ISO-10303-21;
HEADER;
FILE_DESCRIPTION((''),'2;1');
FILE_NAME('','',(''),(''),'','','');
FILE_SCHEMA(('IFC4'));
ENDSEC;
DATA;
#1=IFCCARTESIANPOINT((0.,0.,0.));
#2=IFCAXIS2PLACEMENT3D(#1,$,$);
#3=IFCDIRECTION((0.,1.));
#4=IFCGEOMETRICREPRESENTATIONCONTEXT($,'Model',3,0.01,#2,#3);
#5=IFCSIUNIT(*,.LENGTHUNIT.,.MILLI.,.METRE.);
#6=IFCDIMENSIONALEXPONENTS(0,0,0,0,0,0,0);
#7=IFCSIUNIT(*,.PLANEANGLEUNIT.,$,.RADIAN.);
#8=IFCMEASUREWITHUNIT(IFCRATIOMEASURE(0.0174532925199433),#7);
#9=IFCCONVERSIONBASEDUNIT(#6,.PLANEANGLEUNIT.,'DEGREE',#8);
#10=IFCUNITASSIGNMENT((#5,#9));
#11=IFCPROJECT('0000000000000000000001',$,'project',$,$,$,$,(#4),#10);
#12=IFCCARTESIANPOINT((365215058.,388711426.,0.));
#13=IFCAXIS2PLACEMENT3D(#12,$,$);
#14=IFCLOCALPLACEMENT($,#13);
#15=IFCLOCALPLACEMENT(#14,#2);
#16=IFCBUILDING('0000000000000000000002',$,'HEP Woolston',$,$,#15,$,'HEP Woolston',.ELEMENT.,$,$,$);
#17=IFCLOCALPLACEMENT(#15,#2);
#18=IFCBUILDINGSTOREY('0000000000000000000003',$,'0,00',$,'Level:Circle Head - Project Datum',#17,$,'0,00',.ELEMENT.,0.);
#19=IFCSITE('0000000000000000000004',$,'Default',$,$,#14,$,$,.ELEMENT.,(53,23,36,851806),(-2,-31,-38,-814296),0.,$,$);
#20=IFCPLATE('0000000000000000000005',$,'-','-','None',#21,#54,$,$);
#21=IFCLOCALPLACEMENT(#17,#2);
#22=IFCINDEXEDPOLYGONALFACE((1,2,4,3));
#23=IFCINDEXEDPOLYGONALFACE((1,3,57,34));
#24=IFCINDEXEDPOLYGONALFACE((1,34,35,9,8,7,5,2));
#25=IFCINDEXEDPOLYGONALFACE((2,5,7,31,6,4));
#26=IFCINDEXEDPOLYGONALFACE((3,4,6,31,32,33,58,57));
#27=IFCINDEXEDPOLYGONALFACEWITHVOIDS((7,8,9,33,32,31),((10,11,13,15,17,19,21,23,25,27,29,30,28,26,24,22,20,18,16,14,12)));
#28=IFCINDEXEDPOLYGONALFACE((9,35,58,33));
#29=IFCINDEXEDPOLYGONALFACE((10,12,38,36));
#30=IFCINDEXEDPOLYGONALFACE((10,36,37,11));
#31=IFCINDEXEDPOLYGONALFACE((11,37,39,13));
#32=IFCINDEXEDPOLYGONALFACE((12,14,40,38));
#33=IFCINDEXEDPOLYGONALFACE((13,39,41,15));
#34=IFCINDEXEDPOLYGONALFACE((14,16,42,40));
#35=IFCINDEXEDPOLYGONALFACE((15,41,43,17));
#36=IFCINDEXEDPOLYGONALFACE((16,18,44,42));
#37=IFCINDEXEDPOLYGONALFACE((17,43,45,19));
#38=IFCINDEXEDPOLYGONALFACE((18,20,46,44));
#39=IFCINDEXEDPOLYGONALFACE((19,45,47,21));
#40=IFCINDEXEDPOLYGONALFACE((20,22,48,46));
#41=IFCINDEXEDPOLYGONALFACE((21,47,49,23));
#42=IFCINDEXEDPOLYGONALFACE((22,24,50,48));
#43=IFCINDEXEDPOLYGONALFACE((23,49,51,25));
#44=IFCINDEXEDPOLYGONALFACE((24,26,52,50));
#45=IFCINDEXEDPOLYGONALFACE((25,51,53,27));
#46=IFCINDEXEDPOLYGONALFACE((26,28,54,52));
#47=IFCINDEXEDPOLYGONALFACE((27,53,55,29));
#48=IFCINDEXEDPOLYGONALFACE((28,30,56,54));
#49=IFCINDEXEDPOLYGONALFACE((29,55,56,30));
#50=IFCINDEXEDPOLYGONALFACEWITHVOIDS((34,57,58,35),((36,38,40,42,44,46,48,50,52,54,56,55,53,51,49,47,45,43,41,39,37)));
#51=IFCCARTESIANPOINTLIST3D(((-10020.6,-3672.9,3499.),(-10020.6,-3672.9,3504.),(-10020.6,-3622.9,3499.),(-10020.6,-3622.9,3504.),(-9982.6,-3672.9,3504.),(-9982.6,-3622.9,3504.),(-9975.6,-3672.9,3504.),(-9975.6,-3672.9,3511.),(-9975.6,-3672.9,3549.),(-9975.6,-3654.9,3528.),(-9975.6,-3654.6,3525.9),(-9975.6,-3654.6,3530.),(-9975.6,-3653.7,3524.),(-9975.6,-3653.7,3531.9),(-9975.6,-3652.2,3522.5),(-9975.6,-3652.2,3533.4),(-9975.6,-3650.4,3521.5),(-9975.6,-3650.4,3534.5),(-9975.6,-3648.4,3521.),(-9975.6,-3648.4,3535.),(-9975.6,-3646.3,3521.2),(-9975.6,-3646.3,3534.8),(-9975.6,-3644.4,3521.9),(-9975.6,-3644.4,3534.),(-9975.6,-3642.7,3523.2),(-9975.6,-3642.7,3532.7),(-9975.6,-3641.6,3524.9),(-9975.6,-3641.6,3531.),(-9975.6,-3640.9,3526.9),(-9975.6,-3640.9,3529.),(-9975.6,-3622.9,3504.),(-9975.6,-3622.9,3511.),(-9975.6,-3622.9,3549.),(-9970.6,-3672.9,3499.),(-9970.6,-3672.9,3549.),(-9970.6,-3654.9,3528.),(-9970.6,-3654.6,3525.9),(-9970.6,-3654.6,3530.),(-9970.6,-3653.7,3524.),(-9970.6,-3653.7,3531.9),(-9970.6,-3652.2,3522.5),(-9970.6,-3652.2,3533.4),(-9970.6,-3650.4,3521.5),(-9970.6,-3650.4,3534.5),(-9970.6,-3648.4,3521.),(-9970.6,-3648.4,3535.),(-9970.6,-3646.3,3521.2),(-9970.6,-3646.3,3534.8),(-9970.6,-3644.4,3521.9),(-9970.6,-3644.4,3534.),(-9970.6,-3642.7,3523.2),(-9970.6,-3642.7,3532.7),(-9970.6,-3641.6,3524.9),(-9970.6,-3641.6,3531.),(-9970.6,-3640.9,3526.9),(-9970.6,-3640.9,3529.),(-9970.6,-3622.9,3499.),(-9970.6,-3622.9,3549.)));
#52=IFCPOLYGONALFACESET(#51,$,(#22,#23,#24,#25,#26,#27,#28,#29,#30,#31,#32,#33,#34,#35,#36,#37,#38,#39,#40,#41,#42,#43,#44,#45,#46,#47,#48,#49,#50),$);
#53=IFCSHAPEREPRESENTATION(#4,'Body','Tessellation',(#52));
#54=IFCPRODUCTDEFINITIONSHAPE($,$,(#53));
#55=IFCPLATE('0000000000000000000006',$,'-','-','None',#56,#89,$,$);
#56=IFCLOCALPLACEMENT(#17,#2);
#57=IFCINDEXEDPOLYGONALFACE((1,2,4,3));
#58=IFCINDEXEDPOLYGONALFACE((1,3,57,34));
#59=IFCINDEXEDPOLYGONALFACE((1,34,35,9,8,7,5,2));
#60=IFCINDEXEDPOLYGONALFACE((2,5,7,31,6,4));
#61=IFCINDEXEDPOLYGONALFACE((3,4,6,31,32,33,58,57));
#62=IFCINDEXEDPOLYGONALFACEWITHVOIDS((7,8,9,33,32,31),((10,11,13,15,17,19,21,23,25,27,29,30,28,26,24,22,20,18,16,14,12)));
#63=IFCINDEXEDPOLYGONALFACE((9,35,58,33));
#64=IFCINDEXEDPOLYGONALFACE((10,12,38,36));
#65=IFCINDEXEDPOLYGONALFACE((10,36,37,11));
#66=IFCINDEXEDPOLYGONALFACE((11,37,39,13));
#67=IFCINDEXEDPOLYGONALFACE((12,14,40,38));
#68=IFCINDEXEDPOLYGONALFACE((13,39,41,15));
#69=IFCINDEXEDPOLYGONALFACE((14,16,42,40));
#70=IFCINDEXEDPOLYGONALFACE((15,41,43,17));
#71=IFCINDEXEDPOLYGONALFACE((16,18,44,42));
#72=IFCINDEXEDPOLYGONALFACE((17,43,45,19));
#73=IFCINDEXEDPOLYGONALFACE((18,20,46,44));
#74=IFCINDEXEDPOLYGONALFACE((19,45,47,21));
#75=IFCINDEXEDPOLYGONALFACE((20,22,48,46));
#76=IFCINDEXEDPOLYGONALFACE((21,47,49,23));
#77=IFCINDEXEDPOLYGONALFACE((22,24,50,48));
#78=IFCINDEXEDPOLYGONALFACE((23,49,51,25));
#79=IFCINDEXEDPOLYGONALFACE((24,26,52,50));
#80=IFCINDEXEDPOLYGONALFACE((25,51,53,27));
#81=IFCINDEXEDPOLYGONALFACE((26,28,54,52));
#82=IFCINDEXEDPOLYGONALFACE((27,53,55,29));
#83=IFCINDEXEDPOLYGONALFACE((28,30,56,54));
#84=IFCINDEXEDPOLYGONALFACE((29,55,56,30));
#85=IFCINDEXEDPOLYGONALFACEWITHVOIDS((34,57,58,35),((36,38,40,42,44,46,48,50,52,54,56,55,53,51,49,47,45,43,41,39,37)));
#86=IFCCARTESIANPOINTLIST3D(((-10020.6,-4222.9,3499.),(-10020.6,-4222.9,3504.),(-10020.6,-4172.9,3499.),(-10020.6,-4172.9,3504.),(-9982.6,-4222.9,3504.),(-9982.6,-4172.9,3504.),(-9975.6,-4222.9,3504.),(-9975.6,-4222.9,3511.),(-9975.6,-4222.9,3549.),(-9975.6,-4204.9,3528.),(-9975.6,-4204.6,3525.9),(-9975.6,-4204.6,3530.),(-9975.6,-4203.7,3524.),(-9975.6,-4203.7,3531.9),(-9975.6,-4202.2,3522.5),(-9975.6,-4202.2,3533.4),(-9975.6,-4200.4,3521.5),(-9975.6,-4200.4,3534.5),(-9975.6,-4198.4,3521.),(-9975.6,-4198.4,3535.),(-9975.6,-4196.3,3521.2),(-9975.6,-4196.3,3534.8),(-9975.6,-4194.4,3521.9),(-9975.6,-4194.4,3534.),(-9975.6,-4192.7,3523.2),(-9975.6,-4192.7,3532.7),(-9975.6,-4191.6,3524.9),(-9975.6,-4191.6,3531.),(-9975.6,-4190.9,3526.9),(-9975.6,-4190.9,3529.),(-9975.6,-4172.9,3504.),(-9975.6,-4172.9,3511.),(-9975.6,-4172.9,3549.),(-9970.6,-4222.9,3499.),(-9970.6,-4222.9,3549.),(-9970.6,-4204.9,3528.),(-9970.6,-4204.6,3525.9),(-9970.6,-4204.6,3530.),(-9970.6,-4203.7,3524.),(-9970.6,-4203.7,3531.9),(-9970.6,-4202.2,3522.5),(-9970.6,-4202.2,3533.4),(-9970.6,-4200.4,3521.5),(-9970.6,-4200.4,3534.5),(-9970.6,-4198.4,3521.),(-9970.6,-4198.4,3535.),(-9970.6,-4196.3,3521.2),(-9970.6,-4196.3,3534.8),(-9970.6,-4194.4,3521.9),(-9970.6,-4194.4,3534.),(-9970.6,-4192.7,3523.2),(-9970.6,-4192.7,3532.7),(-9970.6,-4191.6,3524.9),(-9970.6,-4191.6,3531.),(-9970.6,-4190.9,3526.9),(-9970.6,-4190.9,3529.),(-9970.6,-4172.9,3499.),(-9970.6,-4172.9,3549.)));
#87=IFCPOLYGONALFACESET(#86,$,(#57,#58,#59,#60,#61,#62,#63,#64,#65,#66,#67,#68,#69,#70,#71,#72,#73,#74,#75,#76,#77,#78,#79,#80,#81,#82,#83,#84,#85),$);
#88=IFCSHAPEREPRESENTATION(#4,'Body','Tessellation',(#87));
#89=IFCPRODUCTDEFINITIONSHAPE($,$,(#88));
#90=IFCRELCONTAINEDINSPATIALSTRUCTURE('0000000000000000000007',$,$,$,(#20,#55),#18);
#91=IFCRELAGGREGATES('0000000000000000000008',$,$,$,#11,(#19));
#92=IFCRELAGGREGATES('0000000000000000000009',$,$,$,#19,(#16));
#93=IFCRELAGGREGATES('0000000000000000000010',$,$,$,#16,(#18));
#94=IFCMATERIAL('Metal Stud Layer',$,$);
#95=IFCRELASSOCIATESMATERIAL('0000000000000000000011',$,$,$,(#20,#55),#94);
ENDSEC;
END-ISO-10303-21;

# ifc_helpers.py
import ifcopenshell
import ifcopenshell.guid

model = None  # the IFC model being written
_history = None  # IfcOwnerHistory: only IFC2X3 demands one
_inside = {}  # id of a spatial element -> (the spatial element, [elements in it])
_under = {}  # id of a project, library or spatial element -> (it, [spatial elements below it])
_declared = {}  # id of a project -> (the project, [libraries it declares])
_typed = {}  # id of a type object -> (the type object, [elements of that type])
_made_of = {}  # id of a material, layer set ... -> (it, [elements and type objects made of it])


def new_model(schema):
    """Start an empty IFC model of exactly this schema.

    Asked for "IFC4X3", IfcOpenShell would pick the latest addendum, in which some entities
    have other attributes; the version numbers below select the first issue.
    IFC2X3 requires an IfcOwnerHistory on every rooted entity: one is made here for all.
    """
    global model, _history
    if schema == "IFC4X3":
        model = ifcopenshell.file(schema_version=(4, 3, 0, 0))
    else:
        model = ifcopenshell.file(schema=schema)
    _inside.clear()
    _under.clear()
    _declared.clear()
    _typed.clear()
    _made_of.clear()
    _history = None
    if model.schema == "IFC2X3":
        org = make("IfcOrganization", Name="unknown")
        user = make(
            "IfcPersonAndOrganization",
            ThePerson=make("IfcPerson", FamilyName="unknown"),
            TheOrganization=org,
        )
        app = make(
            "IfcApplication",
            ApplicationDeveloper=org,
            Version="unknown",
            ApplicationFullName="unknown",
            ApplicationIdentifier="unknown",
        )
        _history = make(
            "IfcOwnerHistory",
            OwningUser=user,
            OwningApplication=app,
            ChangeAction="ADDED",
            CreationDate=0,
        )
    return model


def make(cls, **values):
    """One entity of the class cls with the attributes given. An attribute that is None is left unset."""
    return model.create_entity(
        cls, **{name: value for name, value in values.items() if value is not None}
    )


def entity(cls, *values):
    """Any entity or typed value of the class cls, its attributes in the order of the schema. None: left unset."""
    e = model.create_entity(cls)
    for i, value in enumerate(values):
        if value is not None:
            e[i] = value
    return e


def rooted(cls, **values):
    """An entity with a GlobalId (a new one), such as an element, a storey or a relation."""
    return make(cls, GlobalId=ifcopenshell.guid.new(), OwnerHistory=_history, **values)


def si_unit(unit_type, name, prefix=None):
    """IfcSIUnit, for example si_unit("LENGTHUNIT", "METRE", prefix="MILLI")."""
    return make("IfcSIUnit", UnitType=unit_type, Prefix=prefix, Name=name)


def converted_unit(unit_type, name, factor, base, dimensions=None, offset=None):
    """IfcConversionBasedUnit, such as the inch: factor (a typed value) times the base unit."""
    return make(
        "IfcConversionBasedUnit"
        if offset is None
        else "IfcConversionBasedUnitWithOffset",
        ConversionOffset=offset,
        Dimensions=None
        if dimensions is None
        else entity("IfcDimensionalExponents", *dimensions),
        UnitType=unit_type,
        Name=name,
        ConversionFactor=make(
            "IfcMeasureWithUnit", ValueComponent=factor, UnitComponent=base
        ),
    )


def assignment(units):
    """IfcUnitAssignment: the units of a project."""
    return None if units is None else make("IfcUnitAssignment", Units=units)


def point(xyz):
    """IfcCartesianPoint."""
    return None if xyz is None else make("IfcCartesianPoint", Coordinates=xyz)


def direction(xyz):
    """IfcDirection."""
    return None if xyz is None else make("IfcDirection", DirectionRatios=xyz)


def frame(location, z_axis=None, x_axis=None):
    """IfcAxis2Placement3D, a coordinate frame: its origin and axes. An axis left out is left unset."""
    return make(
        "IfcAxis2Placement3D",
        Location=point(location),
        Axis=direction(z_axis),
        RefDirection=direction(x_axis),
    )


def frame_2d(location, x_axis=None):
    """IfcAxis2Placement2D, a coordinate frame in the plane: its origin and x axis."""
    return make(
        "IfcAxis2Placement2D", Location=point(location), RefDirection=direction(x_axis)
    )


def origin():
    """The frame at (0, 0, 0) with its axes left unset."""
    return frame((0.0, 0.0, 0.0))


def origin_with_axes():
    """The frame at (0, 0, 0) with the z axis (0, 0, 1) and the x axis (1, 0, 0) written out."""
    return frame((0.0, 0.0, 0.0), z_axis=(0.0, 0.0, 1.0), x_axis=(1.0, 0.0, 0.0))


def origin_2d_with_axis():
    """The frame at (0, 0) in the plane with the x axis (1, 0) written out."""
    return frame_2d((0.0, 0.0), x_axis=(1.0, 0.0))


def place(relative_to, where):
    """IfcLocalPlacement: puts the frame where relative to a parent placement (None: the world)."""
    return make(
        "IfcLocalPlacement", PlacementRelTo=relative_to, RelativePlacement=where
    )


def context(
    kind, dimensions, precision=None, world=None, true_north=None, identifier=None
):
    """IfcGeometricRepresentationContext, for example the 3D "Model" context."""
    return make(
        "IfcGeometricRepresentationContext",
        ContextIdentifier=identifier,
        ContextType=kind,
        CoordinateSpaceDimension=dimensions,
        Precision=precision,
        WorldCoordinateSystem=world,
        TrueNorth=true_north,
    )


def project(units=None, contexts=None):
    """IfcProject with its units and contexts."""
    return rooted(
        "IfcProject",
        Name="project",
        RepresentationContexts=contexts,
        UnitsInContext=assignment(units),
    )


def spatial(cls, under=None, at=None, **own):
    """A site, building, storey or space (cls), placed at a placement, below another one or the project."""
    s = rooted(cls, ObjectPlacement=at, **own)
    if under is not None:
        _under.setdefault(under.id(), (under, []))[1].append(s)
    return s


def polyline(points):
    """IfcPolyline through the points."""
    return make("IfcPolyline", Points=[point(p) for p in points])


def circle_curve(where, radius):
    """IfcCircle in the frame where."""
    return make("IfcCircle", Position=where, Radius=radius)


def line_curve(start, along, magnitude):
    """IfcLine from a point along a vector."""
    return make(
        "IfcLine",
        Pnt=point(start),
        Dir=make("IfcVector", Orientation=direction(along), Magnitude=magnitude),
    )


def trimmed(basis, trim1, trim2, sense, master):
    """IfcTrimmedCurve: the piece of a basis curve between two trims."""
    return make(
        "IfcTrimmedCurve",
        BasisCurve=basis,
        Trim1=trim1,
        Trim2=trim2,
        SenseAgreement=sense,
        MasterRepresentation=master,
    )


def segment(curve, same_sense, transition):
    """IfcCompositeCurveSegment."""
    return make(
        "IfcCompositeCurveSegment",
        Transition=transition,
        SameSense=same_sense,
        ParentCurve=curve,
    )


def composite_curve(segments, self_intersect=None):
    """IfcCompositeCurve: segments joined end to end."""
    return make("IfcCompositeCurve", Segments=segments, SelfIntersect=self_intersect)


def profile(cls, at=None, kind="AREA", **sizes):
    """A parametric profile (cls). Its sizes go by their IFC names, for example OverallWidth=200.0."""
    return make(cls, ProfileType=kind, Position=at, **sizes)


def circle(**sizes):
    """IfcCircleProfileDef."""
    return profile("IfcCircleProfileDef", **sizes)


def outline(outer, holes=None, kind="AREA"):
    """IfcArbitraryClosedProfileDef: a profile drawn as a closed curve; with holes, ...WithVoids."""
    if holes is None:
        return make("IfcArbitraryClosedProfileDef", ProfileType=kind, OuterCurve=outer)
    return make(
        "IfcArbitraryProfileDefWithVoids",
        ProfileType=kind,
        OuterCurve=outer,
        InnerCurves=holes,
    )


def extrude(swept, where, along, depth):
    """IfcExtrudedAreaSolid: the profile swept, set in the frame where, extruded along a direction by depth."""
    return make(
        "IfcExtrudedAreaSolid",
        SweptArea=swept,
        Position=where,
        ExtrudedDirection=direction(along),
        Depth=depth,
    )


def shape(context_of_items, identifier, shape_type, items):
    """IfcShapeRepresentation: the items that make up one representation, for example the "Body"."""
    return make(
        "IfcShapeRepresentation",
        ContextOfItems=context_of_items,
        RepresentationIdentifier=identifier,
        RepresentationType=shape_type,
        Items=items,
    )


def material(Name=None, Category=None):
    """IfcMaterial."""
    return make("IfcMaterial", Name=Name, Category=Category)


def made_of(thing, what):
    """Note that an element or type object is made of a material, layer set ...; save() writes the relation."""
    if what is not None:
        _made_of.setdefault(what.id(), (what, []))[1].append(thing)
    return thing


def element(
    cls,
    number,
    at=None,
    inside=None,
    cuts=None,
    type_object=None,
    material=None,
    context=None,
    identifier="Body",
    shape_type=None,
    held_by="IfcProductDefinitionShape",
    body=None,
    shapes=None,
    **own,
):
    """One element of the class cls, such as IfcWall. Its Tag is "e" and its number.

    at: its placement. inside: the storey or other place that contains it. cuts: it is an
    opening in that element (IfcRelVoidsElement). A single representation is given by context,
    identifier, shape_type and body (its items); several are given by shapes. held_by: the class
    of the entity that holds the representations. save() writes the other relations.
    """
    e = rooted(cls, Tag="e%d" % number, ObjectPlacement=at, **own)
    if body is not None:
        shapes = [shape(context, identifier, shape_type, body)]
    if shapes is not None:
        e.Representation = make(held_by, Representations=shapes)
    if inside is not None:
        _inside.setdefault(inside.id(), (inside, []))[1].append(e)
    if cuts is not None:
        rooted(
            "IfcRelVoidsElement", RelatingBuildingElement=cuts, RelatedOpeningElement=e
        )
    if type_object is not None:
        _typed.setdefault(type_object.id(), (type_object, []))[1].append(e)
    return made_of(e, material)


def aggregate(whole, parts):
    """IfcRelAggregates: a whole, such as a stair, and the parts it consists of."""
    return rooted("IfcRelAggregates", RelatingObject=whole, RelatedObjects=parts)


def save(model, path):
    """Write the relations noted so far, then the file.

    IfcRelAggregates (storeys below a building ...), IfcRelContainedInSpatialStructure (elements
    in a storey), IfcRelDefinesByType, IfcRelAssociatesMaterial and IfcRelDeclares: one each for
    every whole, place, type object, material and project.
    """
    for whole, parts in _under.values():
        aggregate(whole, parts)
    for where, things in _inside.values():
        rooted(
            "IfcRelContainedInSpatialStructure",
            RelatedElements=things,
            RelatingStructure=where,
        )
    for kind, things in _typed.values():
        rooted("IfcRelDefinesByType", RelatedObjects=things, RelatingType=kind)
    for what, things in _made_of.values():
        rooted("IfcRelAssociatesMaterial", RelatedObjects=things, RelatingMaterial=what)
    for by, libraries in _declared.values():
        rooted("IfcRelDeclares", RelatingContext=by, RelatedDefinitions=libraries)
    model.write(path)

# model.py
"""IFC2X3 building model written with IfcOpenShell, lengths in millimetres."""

from ifc_helpers import new_model, entity, si_unit, converted_unit, point, direction, frame, frame_2d, origin, origin_with_axes, origin_2d_with_axis, place, context, project, spatial, polyline, circle_curve, line_curve, trimmed, segment, composite_curve, circle, outline, extrude, material, element, save


model = new_model("IFC2X3")

# Units and contexts
model_context = context("Model", 3, precision=0.01, world=origin(), true_north=direction((0.0, 1.0)))
ifc_project = project(units=[si_unit("LENGTHUNIT", "METRE", prefix="MILLI"), converted_unit("PLANEANGLEUNIT", "DEGREE", entity("IfcRatioMeasure", 0.0174532925199433), si_unit("PLANEANGLEUNIT", "RADIAN"), dimensions=[0, 0, 0, 0, 0, 0, 0])], contexts=[model_context])

# Site, building, storey
site_placement = place(None, frame((365215058.0, 388711426.0, 0.0)))
site = spatial("IfcSite", under=ifc_project, at=site_placement, Name="Default", CompositionType="ELEMENT", RefLatitude=(53, 23, 36, 851806), RefLongitude=(-2, -31, -38, -814296), RefElevation=0.0)
building_placement = place(site_placement, origin())
building = spatial("IfcBuilding", under=site, at=building_placement, Name="HEP Woolston", LongName="HEP Woolston", CompositionType="ELEMENT")
storey_placement = place(building_placement, origin())
storey = spatial("IfcBuildingStorey", under=building, at=storey_placement, Name="0,00", ObjectType="Level:Circle Head - Project Datum", LongName="0,00", CompositionType="ELEMENT", Elevation=0.0)

# Plates, openings
ifc_material = material(Name="Metal Stud Layer")
plate_1_placement = place(storey_placement, frame((-9970.6, -3672.9, 3499.0), z_axis=(0.0, 1.0, 0.0), x_axis=(-1.0, 0.0, 0.0)))
plate_1 = element("IfcPlate", 1, at=plate_1_placement, inside=storey, material=ifc_material, Name="-", Description="-", ObjectType="None", context=model_context, shape_type="SweptSolid", body=[
    extrude(outline(polyline([(0.0, 0.0), (50.0, 0.0), (50.0, 5.0), (5.0, 5.0), (5.0, 50.0), (0.0, 50.0), (0.0, 0.0)])), origin_with_axes(), (0.0, 0.0, 1.0), 50.0),
])
opening_1_placement = place(plate_1_placement, frame((0.0, 0.0, 0.0), z_axis=(0.0, 0.0, 1.0), x_axis=(1.0, 0.0, 0.0)))
element("IfcOpeningElement", 2, at=opening_1_placement, cuts=plate_1, ObjectType="Opening", context=model_context, shape_type="SweptSolid", body=[
    extrude(outline(composite_curve([segment(trimmed(line_curve((50.0, 5.0), (1.0, 0.0), 3.532613), [point((50.0, 5.0))], [point((46.5, 5.0))], True, "CARTESIAN"), True, "CONTINUOUS"), segment(trimmed(circle_curve(frame_2d((46.5, 1.5), x_axis=(-1.0, 0.0)), 3.5), [point((46.5, 5.0))], [point((50.0, 1.5))], False, "CARTESIAN"), True, "CONTINUOUS"), segment(trimmed(line_curve((50.0, 1.5), (0.0, -1.0), 3.532613), [point((50.0, 1.5))], [point((50.0, 5.0))], True, "CARTESIAN"), True, "CONTINUOUS")], self_intersect="UNKNOWN")), origin(), (0.0, 0.0, 1.0), 50.0),
])
opening_2_placement = place(plate_1_placement, origin_with_axes())
element("IfcOpeningElement", 3, at=opening_2_placement, cuts=plate_1, ObjectType="Opening", context=model_context, shape_type="SweptSolid", body=[
    extrude(outline(composite_curve([segment(trimmed(line_curve((5.0, 5.0), (0.0, -1.0), 7.046301), [point((5.0, 5.0))], [point((5.0, 12.0))], False, "CARTESIAN"), True, "CONTINUOUS"), segment(trimmed(circle_curve(frame_2d((12.0, 12.0), x_axis=(1.0, 0.0)), 7.0), [point((5.0, 12.0))], [point((12.0, 5.0))], True, "CARTESIAN"), True, "CONTINUOUS"), segment(trimmed(line_curve((12.0, 5.0), (1.0, 0.0), 7.046301), [point((12.0, 5.0))], [point((5.0, 5.0))], False, "CARTESIAN"), True, "CONTINUOUS")], self_intersect="UNKNOWN")), origin(), (0.0, 0.0, 1.0), 50.0),
])
opening_3_placement = place(plate_1_placement, frame((0.0, 0.0, 0.0), z_axis=(0.0, 0.0, 1.0), x_axis=(1.0, 0.0, 0.0)))
element("IfcOpeningElement", 4, at=opening_3_placement, cuts=plate_1, ObjectType="Opening", context=model_context, shape_type="SweptSolid", body=[
    extrude(outline(composite_curve([segment(trimmed(line_curve((5.0, 50.0), (1.0, 0.0), 3.4874), [point((5.0, 50.0))], [point((1.5, 50.0))], True, "CARTESIAN"), True, "CONTINUOUS"), segment(trimmed(circle_curve(frame_2d((1.5, 46.5), x_axis=(-1.0, 0.0)), 3.5), [point((1.5, 50.0))], [point((5.0, 46.5))], False, "CARTESIAN"), True, "CONTINUOUS"), segment(trimmed(line_curve((5.0, 46.5), (0.0, -1.0), 3.4874), [point((5.0, 46.5))], [point((5.0, 50.0))], True, "CARTESIAN"), True, "CONTINUOUS")], self_intersect="UNKNOWN")), origin(), (0.0, 0.0, 1.0), 50.0),
])
opening_4_placement = place(plate_1_placement, frame((-0.5, 29.0, 25.0), z_axis=(1.0, 0.0, 0.0), x_axis=(0.0, 0.0, -1.0)))
element("IfcOpeningElement", 5, at=opening_4_placement, cuts=plate_1, ObjectType="Opening", context=model_context, shape_type="SweptSolid", body=[
    extrude(circle(Radius=7.0, at=origin_2d_with_axis()), origin(), (0.0, 0.0, 1.0), 6.0),
])
plate_2_placement = place(storey_placement, frame((-9970.6, -4222.9, 3499.0), z_axis=(0.0, 1.0, 0.0), x_axis=(-1.0, 0.0, 0.0)))
plate_2 = element("IfcPlate", 6, at=plate_2_placement, inside=storey, material=ifc_material, Name="-", Description="-", ObjectType="None", context=model_context, shape_type="SweptSolid", body=[
    extrude(outline(polyline([(0.0, 0.0), (50.0, 0.0), (50.0, 5.0), (5.0, 5.0), (5.0, 50.0), (0.0, 50.0), (0.0, 0.0)])), origin_with_axes(), (0.0, 0.0, 1.0), 50.0),
])
opening_5_placement = place(plate_2_placement, frame((0.0, 0.0, 0.0), z_axis=(0.0, 0.0, 1.0), x_axis=(1.0, 0.0, 0.0)))
element("IfcOpeningElement", 7, at=opening_5_placement, cuts=plate_2, ObjectType="Opening", context=model_context, shape_type="SweptSolid", body=[
    extrude(outline(composite_curve([segment(trimmed(line_curve((50.0, 5.0), (1.0, 0.0), 3.532613), [point((50.0, 5.0))], [point((46.5, 5.0))], True, "CARTESIAN"), True, "CONTINUOUS"), segment(trimmed(circle_curve(frame_2d((46.5, 1.5), x_axis=(-1.0, 0.0)), 3.5), [point((46.5, 5.0))], [point((50.0, 1.5))], False, "CARTESIAN"), True, "CONTINUOUS"), segment(trimmed(line_curve((50.0, 1.5), (0.0, -1.0), 3.532613), [point((50.0, 1.5))], [point((50.0, 5.0))], True, "CARTESIAN"), True, "CONTINUOUS")], self_intersect="UNKNOWN")), origin(), (0.0, 0.0, 1.0), 50.0),
])
opening_6_placement = place(plate_2_placement, origin_with_axes())
element("IfcOpeningElement", 8, at=opening_6_placement, cuts=plate_2, ObjectType="Opening", context=model_context, shape_type="SweptSolid", body=[
    extrude(outline(composite_curve([segment(trimmed(line_curve((5.0, 5.0), (0.0, -1.0), 7.046301), [point((5.0, 5.0))], [point((5.0, 12.0))], False, "CARTESIAN"), True, "CONTINUOUS"), segment(trimmed(circle_curve(frame_2d((12.0, 12.0), x_axis=(1.0, 0.0)), 7.0), [point((5.0, 12.0))], [point((12.0, 5.0))], True, "CARTESIAN"), True, "CONTINUOUS"), segment(trimmed(line_curve((12.0, 5.0), (1.0, 0.0), 7.046301), [point((12.0, 5.0))], [point((5.0, 5.0))], False, "CARTESIAN"), True, "CONTINUOUS")], self_intersect="UNKNOWN")), origin(), (0.0, 0.0, 1.0), 50.0),
])
opening_7_placement = place(plate_2_placement, frame((0.0, 0.0, 0.0), z_axis=(0.0, 0.0, 1.0), x_axis=(1.0, 0.0, 0.0)))
element("IfcOpeningElement", 9, at=opening_7_placement, cuts=plate_2, ObjectType="Opening", context=model_context, shape_type="SweptSolid", body=[
    extrude(outline(composite_curve([segment(trimmed(line_curve((5.0, 50.0), (1.0, 0.0), 3.4874), [point((5.0, 50.0))], [point((1.5, 50.0))], True, "CARTESIAN"), True, "CONTINUOUS"), segment(trimmed(circle_curve(frame_2d((1.5, 46.5), x_axis=(-1.0, 0.0)), 3.5), [point((1.5, 50.0))], [point((5.0, 46.5))], False, "CARTESIAN"), True, "CONTINUOUS"), segment(trimmed(line_curve((5.0, 46.5), (0.0, -1.0), 3.4874), [point((5.0, 46.5))], [point((5.0, 50.0))], True, "CARTESIAN"), True, "CONTINUOUS")], self_intersect="UNKNOWN")), origin(), (0.0, 0.0, 1.0), 50.0),
])
opening_8_placement = place(plate_2_placement, frame((-0.5, 29.0, 25.0), z_axis=(1.0, 0.0, 0.0), x_axis=(0.0, 0.0, -1.0)))
element("IfcOpeningElement", 10, at=opening_8_placement, cuts=plate_2, ObjectType="Opening", context=model_context, shape_type="SweptSolid", body=[
    extrude(circle(Radius=7.0, at=origin_2d_with_axis()), origin(), (0.0, 0.0, 1.0), 6.0),
])

save(model, "model.ifc")
